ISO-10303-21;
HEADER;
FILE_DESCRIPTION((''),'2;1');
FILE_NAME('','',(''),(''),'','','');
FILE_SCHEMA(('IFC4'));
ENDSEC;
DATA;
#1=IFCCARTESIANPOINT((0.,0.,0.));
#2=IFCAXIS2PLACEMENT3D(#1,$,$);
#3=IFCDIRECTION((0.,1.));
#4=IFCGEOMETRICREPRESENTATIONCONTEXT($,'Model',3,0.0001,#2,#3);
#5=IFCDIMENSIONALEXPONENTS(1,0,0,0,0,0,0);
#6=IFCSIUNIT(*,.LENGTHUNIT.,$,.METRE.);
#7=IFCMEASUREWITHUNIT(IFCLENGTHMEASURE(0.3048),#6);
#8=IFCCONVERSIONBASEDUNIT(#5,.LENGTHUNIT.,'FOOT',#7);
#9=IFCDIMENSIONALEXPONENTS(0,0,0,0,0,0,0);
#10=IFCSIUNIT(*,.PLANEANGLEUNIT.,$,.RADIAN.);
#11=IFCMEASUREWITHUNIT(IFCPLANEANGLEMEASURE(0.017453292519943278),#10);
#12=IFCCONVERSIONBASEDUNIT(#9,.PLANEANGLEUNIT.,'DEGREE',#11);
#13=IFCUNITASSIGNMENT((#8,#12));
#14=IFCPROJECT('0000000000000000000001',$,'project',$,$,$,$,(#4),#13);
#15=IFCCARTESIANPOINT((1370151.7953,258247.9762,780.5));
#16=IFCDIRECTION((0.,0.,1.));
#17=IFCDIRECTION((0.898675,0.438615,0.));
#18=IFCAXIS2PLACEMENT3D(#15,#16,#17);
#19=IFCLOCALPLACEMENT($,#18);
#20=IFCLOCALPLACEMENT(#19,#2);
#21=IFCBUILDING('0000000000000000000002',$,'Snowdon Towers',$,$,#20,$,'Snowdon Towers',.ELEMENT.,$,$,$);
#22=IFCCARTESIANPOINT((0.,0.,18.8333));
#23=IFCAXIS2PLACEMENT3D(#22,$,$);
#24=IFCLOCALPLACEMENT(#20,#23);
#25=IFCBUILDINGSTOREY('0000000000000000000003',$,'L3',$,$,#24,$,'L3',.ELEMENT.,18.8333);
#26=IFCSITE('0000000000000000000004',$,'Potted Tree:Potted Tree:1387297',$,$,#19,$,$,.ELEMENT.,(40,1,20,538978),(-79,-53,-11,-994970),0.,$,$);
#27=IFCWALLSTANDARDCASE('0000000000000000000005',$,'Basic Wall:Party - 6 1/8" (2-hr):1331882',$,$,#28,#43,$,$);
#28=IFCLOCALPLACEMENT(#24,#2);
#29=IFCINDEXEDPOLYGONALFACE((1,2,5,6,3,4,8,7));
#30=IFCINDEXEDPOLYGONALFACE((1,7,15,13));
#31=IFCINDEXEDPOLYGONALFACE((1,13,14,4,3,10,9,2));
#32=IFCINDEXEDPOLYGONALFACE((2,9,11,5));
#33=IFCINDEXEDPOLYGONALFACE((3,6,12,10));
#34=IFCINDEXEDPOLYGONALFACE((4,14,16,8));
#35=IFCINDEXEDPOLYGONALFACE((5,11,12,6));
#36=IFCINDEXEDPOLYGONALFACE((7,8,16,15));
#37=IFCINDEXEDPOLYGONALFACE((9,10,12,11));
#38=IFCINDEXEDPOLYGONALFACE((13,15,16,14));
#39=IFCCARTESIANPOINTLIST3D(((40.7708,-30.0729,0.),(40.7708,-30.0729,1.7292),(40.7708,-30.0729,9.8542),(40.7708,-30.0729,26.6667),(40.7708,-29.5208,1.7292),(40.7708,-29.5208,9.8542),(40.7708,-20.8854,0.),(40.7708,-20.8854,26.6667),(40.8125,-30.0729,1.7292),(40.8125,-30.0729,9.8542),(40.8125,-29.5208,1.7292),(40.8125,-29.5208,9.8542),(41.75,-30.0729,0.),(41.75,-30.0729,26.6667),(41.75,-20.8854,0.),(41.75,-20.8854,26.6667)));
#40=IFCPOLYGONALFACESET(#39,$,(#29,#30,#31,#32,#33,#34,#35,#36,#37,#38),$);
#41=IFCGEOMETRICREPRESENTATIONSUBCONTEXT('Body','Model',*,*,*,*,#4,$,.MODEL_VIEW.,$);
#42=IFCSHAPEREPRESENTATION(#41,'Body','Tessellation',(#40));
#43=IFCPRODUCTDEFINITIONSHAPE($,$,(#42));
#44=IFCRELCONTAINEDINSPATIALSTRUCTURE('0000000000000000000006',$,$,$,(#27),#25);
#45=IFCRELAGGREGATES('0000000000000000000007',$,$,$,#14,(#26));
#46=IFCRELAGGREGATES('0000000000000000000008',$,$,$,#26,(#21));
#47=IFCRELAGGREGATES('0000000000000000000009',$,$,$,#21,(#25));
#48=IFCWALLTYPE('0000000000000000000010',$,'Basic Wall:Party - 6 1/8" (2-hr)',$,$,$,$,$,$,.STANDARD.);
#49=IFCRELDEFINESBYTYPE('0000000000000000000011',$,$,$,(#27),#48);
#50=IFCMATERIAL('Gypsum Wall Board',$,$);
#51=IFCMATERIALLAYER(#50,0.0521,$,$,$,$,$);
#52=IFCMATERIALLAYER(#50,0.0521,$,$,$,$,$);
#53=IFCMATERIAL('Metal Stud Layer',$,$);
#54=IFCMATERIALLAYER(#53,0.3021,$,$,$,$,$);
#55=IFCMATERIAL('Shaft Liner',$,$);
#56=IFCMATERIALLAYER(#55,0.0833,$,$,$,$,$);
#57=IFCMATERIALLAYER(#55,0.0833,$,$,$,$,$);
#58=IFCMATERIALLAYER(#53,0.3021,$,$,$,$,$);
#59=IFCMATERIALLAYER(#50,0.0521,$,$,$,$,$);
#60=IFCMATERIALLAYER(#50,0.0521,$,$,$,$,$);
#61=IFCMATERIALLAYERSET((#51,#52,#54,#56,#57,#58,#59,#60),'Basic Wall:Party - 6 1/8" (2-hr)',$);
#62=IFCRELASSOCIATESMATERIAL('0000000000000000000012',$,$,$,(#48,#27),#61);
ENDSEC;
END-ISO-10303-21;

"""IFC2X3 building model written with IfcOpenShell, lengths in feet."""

from ifc_helpers import new_model, entity, si_unit, converted_unit, direction, frame, frame_2d, origin, place, context, subcontext, project, spatial, rectangle, extrude, material, layer, layer_set, layer_usage, type_object, element, save


model = new_model("IFC2X3")

# Units and contexts
model_context = context("Model", 3, precision=0.0001, world=origin(), true_north=direction((0.0, 1.0)))
body_context = subcontext(model_context, "Body", "Model", "MODEL_VIEW")
ifc_project = project(units=[converted_unit("LENGTHUNIT", "FOOT", entity("IfcLengthMeasure", 0.3048), si_unit("LENGTHUNIT", "METRE"), dimensions=[1, 0, 0, 0, 0, 0, 0]), converted_unit("PLANEANGLEUNIT", "DEGREE", entity("IfcPlaneAngleMeasure", 0.017453292519943278), si_unit("PLANEANGLEUNIT", "RADIAN"), dimensions=[0, 0, 0, 0, 0, 0, 0])], contexts=[model_context])

# Site, building, storey
site_placement = place(None, frame((1370151.7953, 258247.9762, 780.5), z_axis=(0.0, 0.0, 1.0), x_axis=(0.898675, 0.438615, 0.0)))
site = spatial("IfcSite", under=ifc_project, at=site_placement, Name="Potted Tree:Potted Tree:1387297", CompositionType="ELEMENT", RefLatitude=(40, 1, 20, 538978), RefLongitude=(-79, -53, -11, -994970), RefElevation=0.0)
building_placement = place(site_placement, origin())
building = spatial("IfcBuilding", under=site, at=building_placement, Name="Snowdon Towers", LongName="Snowdon Towers", CompositionType="ELEMENT")
storey_placement = place(building_placement, frame((0.0, 0.0, 18.8333)))
storey = spatial("IfcBuildingStorey", under=building, at=storey_placement, Name="L3", LongName="L3", CompositionType="ELEMENT", Elevation=18.8333)

# Wall, opening
ifc_material_1 = material(Name="Gypsum Wall Board")
ifc_layer_1 = layer(ifc_material_1, 0.0521)
ifc_layer_2 = layer(ifc_material_1, 0.0521)
ifc_material_2 = material(Name="Metal Stud Layer")
ifc_layer_3 = layer(ifc_material_2, 0.3021)
ifc_material_3 = material(Name="Shaft Liner")
ifc_layer_4 = layer(ifc_material_3, 0.0833)
ifc_layer_5 = layer(ifc_material_3, 0.0833)
ifc_layer_6 = layer(ifc_material_2, 0.3021)
ifc_layer_7 = layer(ifc_material_1, 0.0521)
ifc_layer_8 = layer(ifc_material_1, 0.0521)
ifc_layer_set_1 = layer_set([ifc_layer_1, ifc_layer_2, ifc_layer_3, ifc_layer_4, ifc_layer_5, ifc_layer_6, ifc_layer_7, ifc_layer_8], Name="Basic Wall:Party - 6 1/8\" (2-hr)")
ifc_layer_usage_1 = layer_usage(ifc_layer_set_1, "AXIS2", "POSITIVE", -0.4896)
wall_type_1 = type_object("IfcWallType", Name="Basic Wall:Party - 6 1/8\" (2-hr)", PredefinedType="STANDARD", material=ifc_layer_set_1)
wall_1_placement = place(storey_placement, frame((41.2604, -20.8854, 0.0), z_axis=(0.0, 0.0, 1.0), x_axis=(0.0, -1.0, 0.0)))
wall_1 = element("IfcWallStandardCase", 1, at=wall_1_placement, inside=storey, type_object=wall_type_1, material=ifc_layer_usage_1, Name="Basic Wall:Party - 6 1/8\" (2-hr):1331882", context=body_context, shape_type="SweptSolid", body=[
    extrude(rectangle(XDim=9.1875, YDim=0.9792, at=frame_2d((4.5937, 0.0), x_axis=(-1.0, 0.0))), origin(), (0.0, 0.0, 1.0), 26.6667),
])
opening_1_placement = place(wall_1_placement, origin())
element("IfcOpeningElement", 2, at=opening_1_placement, cuts=wall_1, ObjectType="Opening", context=body_context, shape_type="SweptSolid", body=[
    extrude(rectangle(XDim=8.125, YDim=0.5521, at=frame_2d((0.0, 0.0), x_axis=(0.0, 1.0))), frame((8.9115, -4.5729, 5.7917), z_axis=(0.0, 1.0, 0.0), x_axis=(1.0, 0.0, 0.0)), (0.0, 0.0, 1.0), 4.125),
])

save(model, "model.ifc")
